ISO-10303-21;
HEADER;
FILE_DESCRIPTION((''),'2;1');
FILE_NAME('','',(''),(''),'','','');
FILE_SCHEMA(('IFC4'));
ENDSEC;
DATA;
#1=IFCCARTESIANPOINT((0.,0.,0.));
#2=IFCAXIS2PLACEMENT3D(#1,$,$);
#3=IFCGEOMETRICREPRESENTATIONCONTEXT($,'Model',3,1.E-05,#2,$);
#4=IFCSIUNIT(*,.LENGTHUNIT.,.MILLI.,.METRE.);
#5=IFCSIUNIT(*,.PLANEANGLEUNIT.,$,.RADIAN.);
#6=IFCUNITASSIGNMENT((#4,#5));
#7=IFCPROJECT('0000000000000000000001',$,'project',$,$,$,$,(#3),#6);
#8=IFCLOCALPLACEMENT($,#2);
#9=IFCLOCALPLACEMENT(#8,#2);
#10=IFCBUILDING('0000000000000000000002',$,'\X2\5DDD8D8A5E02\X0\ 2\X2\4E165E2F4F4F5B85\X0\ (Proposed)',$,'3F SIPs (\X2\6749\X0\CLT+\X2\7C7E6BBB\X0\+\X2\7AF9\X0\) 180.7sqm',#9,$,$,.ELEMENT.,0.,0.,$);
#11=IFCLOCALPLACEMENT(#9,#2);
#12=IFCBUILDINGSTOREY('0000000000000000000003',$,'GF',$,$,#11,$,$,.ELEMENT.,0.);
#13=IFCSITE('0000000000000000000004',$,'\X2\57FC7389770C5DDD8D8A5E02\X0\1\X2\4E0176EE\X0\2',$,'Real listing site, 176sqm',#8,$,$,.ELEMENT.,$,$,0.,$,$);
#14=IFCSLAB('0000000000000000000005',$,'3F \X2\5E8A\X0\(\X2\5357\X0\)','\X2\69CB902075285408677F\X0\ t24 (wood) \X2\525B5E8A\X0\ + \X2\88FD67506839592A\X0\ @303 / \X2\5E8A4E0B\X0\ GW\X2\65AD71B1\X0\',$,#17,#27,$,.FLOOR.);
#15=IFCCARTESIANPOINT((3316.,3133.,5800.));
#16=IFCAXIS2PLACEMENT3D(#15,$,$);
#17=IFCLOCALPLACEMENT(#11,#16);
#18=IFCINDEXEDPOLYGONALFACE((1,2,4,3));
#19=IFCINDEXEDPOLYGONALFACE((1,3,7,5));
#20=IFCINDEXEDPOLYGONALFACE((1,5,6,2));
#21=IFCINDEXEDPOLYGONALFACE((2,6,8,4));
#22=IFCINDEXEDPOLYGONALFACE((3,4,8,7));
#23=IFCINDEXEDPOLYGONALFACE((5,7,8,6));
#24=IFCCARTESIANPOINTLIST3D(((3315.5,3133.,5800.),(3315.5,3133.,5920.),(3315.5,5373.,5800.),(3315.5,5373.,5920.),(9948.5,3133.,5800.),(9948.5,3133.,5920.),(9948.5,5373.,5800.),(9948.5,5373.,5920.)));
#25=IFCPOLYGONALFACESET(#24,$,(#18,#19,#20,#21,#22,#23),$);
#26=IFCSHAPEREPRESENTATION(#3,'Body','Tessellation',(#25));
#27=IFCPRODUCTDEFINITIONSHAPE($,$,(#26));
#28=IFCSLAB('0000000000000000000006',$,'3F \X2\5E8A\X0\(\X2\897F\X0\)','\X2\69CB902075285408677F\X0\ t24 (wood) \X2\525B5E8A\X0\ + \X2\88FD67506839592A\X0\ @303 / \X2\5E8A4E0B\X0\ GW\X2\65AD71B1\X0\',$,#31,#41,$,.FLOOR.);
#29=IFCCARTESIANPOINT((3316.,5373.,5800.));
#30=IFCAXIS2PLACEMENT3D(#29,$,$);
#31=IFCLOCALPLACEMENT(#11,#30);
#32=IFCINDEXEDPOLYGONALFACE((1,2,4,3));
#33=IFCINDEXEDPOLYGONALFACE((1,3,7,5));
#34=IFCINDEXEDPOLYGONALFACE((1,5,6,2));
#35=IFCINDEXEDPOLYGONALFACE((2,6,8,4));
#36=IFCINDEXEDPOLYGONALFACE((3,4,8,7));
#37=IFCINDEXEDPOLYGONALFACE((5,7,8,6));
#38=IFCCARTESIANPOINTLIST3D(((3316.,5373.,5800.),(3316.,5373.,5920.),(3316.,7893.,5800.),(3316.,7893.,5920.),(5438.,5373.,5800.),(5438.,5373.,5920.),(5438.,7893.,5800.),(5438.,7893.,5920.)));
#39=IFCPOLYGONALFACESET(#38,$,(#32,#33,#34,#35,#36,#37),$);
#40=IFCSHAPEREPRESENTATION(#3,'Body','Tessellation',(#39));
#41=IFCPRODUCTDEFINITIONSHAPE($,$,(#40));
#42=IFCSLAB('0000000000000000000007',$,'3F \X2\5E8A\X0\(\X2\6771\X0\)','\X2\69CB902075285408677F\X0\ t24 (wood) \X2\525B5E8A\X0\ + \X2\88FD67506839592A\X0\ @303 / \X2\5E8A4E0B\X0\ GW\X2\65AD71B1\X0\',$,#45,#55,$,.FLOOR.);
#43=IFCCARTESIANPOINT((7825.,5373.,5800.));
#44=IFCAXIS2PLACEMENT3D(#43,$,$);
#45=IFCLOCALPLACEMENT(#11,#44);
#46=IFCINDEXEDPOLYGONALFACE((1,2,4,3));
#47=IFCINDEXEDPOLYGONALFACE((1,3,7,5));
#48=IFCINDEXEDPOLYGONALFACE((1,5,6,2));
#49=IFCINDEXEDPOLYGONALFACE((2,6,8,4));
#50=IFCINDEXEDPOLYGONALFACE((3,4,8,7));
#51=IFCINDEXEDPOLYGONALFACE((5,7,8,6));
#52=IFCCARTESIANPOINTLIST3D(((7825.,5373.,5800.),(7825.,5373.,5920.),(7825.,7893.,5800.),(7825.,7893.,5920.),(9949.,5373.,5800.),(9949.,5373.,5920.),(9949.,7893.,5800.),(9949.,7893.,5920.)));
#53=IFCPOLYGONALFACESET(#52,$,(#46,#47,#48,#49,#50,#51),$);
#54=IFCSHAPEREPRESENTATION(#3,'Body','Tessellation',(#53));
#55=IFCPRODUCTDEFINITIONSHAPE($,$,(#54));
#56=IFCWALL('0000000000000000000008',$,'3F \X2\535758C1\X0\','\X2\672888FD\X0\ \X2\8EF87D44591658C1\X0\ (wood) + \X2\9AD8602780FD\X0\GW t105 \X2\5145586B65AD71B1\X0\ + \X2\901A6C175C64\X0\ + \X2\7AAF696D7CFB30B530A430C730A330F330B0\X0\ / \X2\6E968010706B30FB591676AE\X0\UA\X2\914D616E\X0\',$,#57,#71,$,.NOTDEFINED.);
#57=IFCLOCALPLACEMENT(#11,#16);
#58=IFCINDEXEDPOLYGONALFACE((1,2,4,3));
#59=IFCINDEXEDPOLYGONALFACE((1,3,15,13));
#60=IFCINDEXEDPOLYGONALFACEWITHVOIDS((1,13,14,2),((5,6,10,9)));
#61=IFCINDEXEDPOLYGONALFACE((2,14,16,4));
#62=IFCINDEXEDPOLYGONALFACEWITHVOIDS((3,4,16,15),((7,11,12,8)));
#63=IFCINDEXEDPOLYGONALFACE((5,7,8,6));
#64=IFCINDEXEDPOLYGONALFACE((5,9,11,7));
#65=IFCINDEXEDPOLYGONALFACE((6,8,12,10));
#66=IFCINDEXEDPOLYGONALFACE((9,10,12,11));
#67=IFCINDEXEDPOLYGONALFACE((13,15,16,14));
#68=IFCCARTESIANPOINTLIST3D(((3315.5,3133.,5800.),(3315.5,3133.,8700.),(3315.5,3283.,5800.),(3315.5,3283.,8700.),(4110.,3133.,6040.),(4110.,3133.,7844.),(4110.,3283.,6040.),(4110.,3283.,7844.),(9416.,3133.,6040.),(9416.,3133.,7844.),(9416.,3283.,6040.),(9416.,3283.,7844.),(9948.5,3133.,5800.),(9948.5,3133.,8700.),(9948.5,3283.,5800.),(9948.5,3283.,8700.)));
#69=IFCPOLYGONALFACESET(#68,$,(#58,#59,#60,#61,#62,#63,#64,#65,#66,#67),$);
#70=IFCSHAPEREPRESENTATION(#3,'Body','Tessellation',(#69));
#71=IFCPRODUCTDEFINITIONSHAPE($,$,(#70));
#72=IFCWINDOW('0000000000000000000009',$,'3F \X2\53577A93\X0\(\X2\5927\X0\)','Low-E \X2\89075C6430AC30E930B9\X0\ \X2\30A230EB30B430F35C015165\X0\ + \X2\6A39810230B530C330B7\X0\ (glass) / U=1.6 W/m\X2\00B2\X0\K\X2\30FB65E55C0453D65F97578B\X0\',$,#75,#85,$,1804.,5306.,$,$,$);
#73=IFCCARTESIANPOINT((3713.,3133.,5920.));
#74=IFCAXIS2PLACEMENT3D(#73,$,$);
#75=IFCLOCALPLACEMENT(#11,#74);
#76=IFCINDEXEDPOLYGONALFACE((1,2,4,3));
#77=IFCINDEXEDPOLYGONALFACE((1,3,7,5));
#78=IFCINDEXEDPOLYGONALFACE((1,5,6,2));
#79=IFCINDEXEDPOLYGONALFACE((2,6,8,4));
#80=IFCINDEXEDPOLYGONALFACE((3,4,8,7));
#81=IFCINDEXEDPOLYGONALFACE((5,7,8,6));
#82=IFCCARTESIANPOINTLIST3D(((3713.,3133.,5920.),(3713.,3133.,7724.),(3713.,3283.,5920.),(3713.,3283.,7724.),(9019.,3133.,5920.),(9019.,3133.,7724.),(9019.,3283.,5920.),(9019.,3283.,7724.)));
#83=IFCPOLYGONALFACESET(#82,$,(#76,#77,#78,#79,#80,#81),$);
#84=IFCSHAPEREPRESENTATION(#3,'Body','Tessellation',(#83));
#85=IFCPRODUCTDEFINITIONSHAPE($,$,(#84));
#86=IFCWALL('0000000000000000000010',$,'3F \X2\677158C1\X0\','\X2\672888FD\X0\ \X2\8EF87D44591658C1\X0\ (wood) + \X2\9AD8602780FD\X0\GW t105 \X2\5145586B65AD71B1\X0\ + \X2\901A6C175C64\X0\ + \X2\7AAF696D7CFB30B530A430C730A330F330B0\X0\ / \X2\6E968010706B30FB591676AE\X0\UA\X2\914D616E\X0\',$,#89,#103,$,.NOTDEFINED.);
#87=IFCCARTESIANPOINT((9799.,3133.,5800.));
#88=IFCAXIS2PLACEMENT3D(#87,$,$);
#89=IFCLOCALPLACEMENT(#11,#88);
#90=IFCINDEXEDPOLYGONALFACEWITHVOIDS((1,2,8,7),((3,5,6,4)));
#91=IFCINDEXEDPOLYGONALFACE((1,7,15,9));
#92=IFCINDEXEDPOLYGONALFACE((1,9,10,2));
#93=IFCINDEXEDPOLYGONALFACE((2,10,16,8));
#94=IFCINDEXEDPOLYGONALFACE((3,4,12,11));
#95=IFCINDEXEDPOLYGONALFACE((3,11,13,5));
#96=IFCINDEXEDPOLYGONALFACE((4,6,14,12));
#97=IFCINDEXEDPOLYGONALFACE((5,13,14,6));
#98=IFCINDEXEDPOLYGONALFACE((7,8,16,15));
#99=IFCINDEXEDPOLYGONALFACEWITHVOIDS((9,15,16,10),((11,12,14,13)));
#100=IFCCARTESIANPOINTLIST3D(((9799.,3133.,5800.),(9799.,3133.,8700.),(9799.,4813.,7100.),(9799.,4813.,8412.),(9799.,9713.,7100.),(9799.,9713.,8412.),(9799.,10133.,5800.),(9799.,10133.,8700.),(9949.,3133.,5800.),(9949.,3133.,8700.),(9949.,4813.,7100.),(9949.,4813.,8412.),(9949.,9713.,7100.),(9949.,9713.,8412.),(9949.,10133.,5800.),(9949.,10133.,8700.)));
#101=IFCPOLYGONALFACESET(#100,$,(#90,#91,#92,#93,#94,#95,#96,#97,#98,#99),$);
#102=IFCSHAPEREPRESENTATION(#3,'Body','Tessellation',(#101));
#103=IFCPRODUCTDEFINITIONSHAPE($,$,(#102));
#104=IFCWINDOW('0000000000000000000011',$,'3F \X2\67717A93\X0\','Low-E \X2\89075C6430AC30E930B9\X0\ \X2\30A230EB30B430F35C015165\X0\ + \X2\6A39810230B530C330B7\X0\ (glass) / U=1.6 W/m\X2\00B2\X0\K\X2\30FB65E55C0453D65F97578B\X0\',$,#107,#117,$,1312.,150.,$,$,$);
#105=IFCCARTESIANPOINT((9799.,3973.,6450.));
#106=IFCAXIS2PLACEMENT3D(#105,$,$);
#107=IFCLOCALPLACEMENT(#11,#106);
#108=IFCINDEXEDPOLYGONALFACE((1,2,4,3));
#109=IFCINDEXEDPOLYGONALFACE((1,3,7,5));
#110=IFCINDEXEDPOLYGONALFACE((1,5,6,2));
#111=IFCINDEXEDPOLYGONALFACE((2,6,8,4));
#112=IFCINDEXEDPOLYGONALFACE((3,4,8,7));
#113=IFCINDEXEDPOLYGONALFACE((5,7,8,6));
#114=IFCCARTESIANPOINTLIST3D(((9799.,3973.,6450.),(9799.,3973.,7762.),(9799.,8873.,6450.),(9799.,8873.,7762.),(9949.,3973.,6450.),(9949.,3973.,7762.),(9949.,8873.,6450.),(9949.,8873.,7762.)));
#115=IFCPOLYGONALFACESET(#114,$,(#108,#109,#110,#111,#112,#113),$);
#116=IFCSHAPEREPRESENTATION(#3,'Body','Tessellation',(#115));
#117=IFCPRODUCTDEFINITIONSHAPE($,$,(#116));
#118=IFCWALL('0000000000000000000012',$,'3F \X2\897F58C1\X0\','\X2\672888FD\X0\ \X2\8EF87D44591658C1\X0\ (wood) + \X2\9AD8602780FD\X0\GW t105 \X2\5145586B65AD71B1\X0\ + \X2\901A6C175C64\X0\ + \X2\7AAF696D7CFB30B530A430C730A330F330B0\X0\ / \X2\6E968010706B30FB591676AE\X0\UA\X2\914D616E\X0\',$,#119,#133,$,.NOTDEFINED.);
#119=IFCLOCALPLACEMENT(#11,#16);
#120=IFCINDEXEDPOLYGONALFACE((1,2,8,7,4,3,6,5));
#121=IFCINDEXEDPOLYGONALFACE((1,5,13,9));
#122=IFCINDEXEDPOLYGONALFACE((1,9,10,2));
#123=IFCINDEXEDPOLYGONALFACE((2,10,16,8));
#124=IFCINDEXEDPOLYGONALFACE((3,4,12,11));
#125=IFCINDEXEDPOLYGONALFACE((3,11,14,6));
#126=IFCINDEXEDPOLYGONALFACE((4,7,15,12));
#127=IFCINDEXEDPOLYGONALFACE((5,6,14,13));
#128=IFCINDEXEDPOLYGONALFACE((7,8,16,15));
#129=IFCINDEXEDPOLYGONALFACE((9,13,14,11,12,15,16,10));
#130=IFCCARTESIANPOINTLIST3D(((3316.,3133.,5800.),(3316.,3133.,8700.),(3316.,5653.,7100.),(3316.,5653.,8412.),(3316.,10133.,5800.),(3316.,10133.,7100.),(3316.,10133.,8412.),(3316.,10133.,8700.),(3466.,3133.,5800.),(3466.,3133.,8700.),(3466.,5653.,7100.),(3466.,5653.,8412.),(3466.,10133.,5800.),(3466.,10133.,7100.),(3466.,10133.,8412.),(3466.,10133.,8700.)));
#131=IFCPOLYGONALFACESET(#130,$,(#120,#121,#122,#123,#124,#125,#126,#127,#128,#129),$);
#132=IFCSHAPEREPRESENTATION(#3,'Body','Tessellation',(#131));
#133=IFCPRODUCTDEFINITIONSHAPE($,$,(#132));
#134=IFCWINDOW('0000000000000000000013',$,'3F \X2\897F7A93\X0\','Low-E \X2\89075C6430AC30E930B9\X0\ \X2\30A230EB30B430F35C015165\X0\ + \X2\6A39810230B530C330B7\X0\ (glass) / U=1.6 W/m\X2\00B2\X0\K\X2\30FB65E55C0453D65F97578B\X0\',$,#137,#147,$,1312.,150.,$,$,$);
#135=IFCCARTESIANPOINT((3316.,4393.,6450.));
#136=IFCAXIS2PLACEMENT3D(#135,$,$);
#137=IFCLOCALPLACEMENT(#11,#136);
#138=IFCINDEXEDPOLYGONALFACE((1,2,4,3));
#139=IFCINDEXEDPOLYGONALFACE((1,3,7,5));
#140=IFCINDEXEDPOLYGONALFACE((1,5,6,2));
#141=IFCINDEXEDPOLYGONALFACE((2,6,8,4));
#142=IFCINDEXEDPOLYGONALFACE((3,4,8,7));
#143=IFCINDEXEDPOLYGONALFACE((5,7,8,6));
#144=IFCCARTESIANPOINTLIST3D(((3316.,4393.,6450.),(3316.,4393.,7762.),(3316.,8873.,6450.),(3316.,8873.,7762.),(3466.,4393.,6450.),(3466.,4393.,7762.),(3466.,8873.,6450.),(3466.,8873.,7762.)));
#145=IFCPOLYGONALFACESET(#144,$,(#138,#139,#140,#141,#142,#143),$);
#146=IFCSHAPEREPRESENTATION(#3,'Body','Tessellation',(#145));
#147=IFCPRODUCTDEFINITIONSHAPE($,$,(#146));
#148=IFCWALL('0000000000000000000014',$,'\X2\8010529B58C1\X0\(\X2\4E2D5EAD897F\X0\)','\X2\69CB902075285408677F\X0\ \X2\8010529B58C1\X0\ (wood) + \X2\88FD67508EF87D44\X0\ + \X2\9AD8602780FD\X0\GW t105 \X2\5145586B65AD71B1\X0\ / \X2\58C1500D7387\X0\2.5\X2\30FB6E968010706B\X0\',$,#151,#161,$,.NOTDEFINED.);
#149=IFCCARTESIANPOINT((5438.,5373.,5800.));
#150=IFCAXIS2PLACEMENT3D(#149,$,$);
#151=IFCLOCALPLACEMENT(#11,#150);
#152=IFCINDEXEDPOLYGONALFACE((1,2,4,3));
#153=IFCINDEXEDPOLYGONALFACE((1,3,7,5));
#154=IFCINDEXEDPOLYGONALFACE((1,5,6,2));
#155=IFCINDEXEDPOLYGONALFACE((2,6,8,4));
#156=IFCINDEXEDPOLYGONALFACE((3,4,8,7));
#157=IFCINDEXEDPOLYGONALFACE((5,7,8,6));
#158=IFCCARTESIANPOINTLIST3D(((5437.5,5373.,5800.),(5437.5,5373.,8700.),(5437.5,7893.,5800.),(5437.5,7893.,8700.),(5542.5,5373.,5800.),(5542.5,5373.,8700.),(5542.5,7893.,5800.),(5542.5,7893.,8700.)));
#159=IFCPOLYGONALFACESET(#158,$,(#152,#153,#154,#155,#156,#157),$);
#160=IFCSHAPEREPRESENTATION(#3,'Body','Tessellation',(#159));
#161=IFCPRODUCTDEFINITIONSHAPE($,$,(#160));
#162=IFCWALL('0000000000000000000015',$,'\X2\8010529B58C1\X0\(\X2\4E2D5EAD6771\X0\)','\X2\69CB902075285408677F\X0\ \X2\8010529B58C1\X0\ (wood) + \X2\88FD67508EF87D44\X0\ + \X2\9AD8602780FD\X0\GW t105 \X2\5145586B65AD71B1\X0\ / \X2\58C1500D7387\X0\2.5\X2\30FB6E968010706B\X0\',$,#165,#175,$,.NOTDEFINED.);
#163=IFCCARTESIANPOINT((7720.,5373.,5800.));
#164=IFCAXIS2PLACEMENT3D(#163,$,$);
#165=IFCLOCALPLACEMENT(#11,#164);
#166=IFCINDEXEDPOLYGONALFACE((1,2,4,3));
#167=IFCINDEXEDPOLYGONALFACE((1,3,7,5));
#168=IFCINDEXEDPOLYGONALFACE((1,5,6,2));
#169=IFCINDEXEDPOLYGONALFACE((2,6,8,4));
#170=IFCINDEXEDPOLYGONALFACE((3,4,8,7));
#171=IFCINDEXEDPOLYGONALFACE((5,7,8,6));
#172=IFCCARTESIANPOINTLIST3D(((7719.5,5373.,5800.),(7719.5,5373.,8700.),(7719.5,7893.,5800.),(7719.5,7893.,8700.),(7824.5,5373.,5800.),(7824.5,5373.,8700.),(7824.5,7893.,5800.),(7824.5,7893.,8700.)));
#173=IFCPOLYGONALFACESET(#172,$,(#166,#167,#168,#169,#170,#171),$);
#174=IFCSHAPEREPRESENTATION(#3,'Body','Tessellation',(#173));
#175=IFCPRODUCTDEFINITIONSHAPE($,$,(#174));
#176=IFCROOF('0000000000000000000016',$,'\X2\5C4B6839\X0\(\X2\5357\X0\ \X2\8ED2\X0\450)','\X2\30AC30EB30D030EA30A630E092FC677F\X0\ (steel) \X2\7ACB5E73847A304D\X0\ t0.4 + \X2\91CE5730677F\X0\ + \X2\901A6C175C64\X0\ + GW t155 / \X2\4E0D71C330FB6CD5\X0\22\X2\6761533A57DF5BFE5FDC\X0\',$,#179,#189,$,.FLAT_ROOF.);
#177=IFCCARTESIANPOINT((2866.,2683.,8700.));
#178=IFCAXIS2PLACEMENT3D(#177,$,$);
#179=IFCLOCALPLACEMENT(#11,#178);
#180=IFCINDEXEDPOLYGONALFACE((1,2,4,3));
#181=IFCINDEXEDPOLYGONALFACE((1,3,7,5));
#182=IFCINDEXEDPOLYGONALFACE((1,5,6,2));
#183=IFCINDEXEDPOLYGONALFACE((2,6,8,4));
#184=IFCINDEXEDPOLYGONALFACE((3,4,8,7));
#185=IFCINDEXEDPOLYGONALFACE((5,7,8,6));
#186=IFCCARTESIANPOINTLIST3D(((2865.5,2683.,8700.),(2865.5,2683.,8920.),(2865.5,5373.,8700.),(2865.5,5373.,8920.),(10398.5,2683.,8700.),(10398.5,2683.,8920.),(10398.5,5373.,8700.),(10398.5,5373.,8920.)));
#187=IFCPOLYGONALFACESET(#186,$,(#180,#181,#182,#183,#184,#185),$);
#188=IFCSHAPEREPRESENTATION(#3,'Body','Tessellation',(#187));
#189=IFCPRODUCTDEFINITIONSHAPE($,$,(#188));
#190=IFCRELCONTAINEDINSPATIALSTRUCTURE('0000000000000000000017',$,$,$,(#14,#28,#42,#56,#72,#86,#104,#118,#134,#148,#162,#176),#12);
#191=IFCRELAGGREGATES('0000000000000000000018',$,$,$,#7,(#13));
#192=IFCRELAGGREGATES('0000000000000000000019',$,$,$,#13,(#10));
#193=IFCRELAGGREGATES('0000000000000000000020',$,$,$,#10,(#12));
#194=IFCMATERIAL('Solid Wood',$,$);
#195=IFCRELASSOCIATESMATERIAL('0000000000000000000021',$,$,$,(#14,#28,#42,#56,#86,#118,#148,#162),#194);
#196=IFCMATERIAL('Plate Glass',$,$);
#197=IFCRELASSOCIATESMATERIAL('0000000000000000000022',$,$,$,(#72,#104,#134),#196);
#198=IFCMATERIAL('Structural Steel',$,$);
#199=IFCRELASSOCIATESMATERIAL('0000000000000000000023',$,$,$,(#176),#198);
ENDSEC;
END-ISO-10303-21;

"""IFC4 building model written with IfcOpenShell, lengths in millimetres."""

from ifc_helpers import new_model, si_unit, frame, frame_2d, origin, place, context, project, spatial, rectangle, extrude, material, element, fill, save


model = new_model("IFC4")

# Units and contexts
model_context = context("Model", 3, precision=1e-05, world=origin())
ifc_project = project(units=[si_unit("LENGTHUNIT", "METRE", prefix="MILLI"), si_unit("PLANEANGLEUNIT", "RADIAN")], contexts=[model_context])

# Site, building, storey
site_placement = place(None, origin())
site = spatial("IfcSite", under=ifc_project, at=site_placement, Name="埼玉県川越市1丁目2", ObjectType="Real listing site, 176sqm", CompositionType="ELEMENT", RefElevation=0.0)
building_placement = place(site_placement, origin())
building = spatial("IfcBuilding", under=site, at=building_placement, Name="川越市 2世帯住宅 (Proposed)", ObjectType="3F SIPs (杉CLT+籾殻+竹) 180.7sqm", CompositionType="ELEMENT", ElevationOfRefHeight=0.0, ElevationOfTerrain=0.0)
storey_placement = place(building_placement, origin())
storey = spatial("IfcBuildingStorey", under=building, at=storey_placement, Name="GF", CompositionType="ELEMENT", Elevation=0.0)

# Slabs
ifc_material_1 = material(Name="Solid Wood")
slab_1_placement = place(storey_placement, frame((3316.0, 3133.0, 5800.0)))
element("IfcSlab", 1, at=slab_1_placement, inside=storey, material=ifc_material_1, Name="3F 床(南)", Description="構造用合板 t24 (wood) 剛床 + 製材根太 @303 / 床下 GW断熱", PredefinedType="FLOOR", context=model_context, shape_type="SweptSolid", body=[
    extrude(rectangle(XDim=6633.0, YDim=2240.0, at=frame_2d((3316.0, 1120.0))), frame((3316.0, 3133.0, 5800.0)), (0.0, 0.0, 1.0), 120.0),
])
slab_2_placement = place(storey_placement, frame((3316.0, 5373.0, 5800.0)))
element("IfcSlab", 2, at=slab_2_placement, inside=storey, material=ifc_material_1, Name="3F 床(西)", Description="構造用合板 t24 (wood) 剛床 + 製材根太 @303 / 床下 GW断熱", PredefinedType="FLOOR", context=model_context, shape_type="SweptSolid", body=[
    extrude(rectangle(XDim=2122.0, YDim=2520.0, at=frame_2d((1061.0, 1260.0))), frame((3316.0, 5373.0, 5800.0)), (0.0, 0.0, 1.0), 120.0),
])
slab_3_placement = place(storey_placement, frame((7825.0, 5373.0, 5800.0)))
element("IfcSlab", 3, at=slab_3_placement, inside=storey, material=ifc_material_1, Name="3F 床(東)", Description="構造用合板 t24 (wood) 剛床 + 製材根太 @303 / 床下 GW断熱", PredefinedType="FLOOR", context=model_context, shape_type="SweptSolid", body=[
    extrude(rectangle(XDim=2124.0, YDim=2520.0, at=frame_2d((1062.0, 1260.0))), frame((7825.0, 5373.0, 5800.0)), (0.0, 0.0, 1.0), 120.0),
])

# Walls, openings, windows
wall_1_placement = place(storey_placement, frame((3316.0, 3133.0, 5800.0)))
wall_1 = element("IfcWall", 4, at=wall_1_placement, inside=storey, material=ifc_material_1, Name="3F 南壁", Description="木製 軸組外壁 (wood) + 高性能GW t105 充填断熱 + 通気層 + 窯業系サイディング / 準耐火・外皮UA配慮", PredefinedType="NOTDEFINED", context=model_context, shape_type="SweptSolid", body=[
    extrude(rectangle(XDim=6633.0, YDim=150.0, at=frame_2d((3316.0, 75.0))), frame((3316.0, 3133.0, 5800.0)), (0.0, 0.0, 1.0), 2900.0),
])
opening_1_placement = place(storey_placement, frame((3713.0, 3133.0, 5920.0)))
opening_1 = element("IfcOpeningElement", 5, at=opening_1_placement, cuts=wall_1, PredefinedType="NOTDEFINED", context=model_context, shape_type="SweptSolid", body=[
    extrude(rectangle(XDim=5306.0, YDim=150.0, at=frame_2d((2653.0, 75.0))), frame((3713.0, 3133.0, 5920.0)), (0.0, 0.0, 1.0), 1804.0),
])
ifc_material_2 = material(Name="Plate Glass")
window_1_placement = place(storey_placement, frame((3713.0, 3133.0, 5920.0)))
window_1 = element("IfcWindow", 6, at=window_1_placement, inside=storey, material=ifc_material_2, Name="3F 南窓(大)", Description="Low-E 複層ガラス アルゴン封入 + 樹脂サッシ (glass) / U=1.6 W/m²K・日射取得型", OverallHeight=1804.0, OverallWidth=5306.0, context=model_context, shape_type="SweptSolid", body=[
    extrude(rectangle(XDim=5306.0, YDim=150.0, at=frame_2d((2653.0, 75.0))), frame((3713.0, 3133.0, 5920.0)), (0.0, 0.0, 1.0), 1804.0),
])
fill(opening_1, window_1)
wall_2_placement = place(storey_placement, frame((9799.0, 3133.0, 5800.0)))
wall_2 = element("IfcWall", 7, at=wall_2_placement, inside=storey, material=ifc_material_1, Name="3F 東壁", Description="木製 軸組外壁 (wood) + 高性能GW t105 充填断熱 + 通気層 + 窯業系サイディング / 準耐火・外皮UA配慮", PredefinedType="NOTDEFINED", context=model_context, shape_type="SweptSolid", body=[
    extrude(rectangle(XDim=150.0, YDim=7000.0, at=frame_2d((75.0, 3500.0))), frame((9799.0, 3133.0, 5800.0)), (0.0, 0.0, 1.0), 2900.0),
])
opening_2_placement = place(storey_placement, frame((9799.0, 3973.0, 6450.0)))
opening_2 = element("IfcOpeningElement", 8, at=opening_2_placement, cuts=wall_2, PredefinedType="NOTDEFINED", context=model_context, shape_type="SweptSolid", body=[
    extrude(rectangle(XDim=150.0, YDim=4900.0, at=frame_2d((75.0, 2450.0))), frame((9799.0, 3973.0, 6450.0)), (0.0, 0.0, 1.0), 1312.0),
])
window_2_placement = place(storey_placement, frame((9799.0, 3973.0, 6450.0)))
window_2 = element("IfcWindow", 9, at=window_2_placement, inside=storey, material=ifc_material_2, Name="3F 東窓", Description="Low-E 複層ガラス アルゴン封入 + 樹脂サッシ (glass) / U=1.6 W/m²K・日射取得型", OverallHeight=1312.0, OverallWidth=150.0, context=model_context, shape_type="SweptSolid", body=[
    extrude(rectangle(XDim=150.0, YDim=4900.0, at=frame_2d((75.0, 2450.0))), frame((9799.0, 3973.0, 6450.0)), (0.0, 0.0, 1.0), 1312.0),
])
fill(opening_2, window_2)
wall_3_placement = place(storey_placement, frame((3316.0, 3133.0, 5800.0)))
wall_3 = element("IfcWall", 10, at=wall_3_placement, inside=storey, material=ifc_material_1, Name="3F 西壁", Description="木製 軸組外壁 (wood) + 高性能GW t105 充填断熱 + 通気層 + 窯業系サイディング / 準耐火・外皮UA配慮", PredefinedType="NOTDEFINED", context=model_context, shape_type="SweptSolid", body=[
    extrude(rectangle(XDim=150.0, YDim=7000.0, at=frame_2d((75.0, 3500.0))), frame((3316.0, 3133.0, 5800.0)), (0.0, 0.0, 1.0), 2900.0),
])
opening_3_placement = place(storey_placement, frame((3316.0, 4393.0, 6450.0)))
opening_3 = element("IfcOpeningElement", 11, at=opening_3_placement, cuts=wall_3, PredefinedType="NOTDEFINED", context=model_context, shape_type="SweptSolid", body=[
    extrude(rectangle(XDim=150.0, YDim=4480.0, at=frame_2d((75.0, 2240.0))), frame((3316.0, 4393.0, 6450.0)), (0.0, 0.0, 1.0), 1312.0),
])
window_3_placement = place(storey_placement, frame((3316.0, 4393.0, 6450.0)))
window_3 = element("IfcWindow", 12, at=window_3_placement, inside=storey, material=ifc_material_2, Name="3F 西窓", Description="Low-E 複層ガラス アルゴン封入 + 樹脂サッシ (glass) / U=1.6 W/m²K・日射取得型", OverallHeight=1312.0, OverallWidth=150.0, context=model_context, shape_type="SweptSolid", body=[
    extrude(rectangle(XDim=150.0, YDim=4480.0, at=frame_2d((75.0, 2240.0))), frame((3316.0, 4393.0, 6450.0)), (0.0, 0.0, 1.0), 1312.0),
])
fill(opening_3, window_3)

# Walls
wall_4_placement = place(storey_placement, frame((5438.0, 5373.0, 5800.0)))
element("IfcWall", 13, at=wall_4_placement, inside=storey, material=ifc_material_1, Name="耐力壁(中庭西)", Description="構造用合板 耐力壁 (wood) + 製材軸組 + 高性能GW t105 充填断熱 / 壁倍率2.5・準耐火", PredefinedType="NOTDEFINED", context=model_context, shape_type="SweptSolid", body=[
    extrude(rectangle(XDim=105.0, YDim=2520.0, at=frame_2d((52.0, 1260.0))), frame((5438.0, 5373.0, 5800.0)), (0.0, 0.0, 1.0), 2900.0),
])
wall_5_placement = place(storey_placement, frame((7720.0, 5373.0, 5800.0)))
element("IfcWall", 14, at=wall_5_placement, inside=storey, material=ifc_material_1, Name="耐力壁(中庭東)", Description="構造用合板 耐力壁 (wood) + 製材軸組 + 高性能GW t105 充填断熱 / 壁倍率2.5・準耐火", PredefinedType="NOTDEFINED", context=model_context, shape_type="SweptSolid", body=[
    extrude(rectangle(XDim=105.0, YDim=2520.0, at=frame_2d((52.0, 1260.0))), frame((7720.0, 5373.0, 5800.0)), (0.0, 0.0, 1.0), 2900.0),
])

# Roof
ifc_material_3 = material(Name="Structural Steel")
roof_1_placement = place(storey_placement, frame((2866.0, 2683.0, 8700.0)))
element("IfcRoof", 15, at=roof_1_placement, inside=storey, material=ifc_material_3, Name="屋根(南 軒450)", Description="ガルバリウム鋼板 (steel) 立平葺き t0.4 + 野地板 + 通気層 + GW t155 / 不燃・法22条区域対応", PredefinedType="FLAT_ROOF", context=model_context, shape_type="SweptSolid", body=[
    extrude(rectangle(XDim=7533.0, YDim=2690.0, at=frame_2d((3766.0, 1345.0))), frame((2866.0, 2683.0, 8700.0)), (0.0, 0.0, 1.0), 220.0),
])

save(model, "model.ifc")
